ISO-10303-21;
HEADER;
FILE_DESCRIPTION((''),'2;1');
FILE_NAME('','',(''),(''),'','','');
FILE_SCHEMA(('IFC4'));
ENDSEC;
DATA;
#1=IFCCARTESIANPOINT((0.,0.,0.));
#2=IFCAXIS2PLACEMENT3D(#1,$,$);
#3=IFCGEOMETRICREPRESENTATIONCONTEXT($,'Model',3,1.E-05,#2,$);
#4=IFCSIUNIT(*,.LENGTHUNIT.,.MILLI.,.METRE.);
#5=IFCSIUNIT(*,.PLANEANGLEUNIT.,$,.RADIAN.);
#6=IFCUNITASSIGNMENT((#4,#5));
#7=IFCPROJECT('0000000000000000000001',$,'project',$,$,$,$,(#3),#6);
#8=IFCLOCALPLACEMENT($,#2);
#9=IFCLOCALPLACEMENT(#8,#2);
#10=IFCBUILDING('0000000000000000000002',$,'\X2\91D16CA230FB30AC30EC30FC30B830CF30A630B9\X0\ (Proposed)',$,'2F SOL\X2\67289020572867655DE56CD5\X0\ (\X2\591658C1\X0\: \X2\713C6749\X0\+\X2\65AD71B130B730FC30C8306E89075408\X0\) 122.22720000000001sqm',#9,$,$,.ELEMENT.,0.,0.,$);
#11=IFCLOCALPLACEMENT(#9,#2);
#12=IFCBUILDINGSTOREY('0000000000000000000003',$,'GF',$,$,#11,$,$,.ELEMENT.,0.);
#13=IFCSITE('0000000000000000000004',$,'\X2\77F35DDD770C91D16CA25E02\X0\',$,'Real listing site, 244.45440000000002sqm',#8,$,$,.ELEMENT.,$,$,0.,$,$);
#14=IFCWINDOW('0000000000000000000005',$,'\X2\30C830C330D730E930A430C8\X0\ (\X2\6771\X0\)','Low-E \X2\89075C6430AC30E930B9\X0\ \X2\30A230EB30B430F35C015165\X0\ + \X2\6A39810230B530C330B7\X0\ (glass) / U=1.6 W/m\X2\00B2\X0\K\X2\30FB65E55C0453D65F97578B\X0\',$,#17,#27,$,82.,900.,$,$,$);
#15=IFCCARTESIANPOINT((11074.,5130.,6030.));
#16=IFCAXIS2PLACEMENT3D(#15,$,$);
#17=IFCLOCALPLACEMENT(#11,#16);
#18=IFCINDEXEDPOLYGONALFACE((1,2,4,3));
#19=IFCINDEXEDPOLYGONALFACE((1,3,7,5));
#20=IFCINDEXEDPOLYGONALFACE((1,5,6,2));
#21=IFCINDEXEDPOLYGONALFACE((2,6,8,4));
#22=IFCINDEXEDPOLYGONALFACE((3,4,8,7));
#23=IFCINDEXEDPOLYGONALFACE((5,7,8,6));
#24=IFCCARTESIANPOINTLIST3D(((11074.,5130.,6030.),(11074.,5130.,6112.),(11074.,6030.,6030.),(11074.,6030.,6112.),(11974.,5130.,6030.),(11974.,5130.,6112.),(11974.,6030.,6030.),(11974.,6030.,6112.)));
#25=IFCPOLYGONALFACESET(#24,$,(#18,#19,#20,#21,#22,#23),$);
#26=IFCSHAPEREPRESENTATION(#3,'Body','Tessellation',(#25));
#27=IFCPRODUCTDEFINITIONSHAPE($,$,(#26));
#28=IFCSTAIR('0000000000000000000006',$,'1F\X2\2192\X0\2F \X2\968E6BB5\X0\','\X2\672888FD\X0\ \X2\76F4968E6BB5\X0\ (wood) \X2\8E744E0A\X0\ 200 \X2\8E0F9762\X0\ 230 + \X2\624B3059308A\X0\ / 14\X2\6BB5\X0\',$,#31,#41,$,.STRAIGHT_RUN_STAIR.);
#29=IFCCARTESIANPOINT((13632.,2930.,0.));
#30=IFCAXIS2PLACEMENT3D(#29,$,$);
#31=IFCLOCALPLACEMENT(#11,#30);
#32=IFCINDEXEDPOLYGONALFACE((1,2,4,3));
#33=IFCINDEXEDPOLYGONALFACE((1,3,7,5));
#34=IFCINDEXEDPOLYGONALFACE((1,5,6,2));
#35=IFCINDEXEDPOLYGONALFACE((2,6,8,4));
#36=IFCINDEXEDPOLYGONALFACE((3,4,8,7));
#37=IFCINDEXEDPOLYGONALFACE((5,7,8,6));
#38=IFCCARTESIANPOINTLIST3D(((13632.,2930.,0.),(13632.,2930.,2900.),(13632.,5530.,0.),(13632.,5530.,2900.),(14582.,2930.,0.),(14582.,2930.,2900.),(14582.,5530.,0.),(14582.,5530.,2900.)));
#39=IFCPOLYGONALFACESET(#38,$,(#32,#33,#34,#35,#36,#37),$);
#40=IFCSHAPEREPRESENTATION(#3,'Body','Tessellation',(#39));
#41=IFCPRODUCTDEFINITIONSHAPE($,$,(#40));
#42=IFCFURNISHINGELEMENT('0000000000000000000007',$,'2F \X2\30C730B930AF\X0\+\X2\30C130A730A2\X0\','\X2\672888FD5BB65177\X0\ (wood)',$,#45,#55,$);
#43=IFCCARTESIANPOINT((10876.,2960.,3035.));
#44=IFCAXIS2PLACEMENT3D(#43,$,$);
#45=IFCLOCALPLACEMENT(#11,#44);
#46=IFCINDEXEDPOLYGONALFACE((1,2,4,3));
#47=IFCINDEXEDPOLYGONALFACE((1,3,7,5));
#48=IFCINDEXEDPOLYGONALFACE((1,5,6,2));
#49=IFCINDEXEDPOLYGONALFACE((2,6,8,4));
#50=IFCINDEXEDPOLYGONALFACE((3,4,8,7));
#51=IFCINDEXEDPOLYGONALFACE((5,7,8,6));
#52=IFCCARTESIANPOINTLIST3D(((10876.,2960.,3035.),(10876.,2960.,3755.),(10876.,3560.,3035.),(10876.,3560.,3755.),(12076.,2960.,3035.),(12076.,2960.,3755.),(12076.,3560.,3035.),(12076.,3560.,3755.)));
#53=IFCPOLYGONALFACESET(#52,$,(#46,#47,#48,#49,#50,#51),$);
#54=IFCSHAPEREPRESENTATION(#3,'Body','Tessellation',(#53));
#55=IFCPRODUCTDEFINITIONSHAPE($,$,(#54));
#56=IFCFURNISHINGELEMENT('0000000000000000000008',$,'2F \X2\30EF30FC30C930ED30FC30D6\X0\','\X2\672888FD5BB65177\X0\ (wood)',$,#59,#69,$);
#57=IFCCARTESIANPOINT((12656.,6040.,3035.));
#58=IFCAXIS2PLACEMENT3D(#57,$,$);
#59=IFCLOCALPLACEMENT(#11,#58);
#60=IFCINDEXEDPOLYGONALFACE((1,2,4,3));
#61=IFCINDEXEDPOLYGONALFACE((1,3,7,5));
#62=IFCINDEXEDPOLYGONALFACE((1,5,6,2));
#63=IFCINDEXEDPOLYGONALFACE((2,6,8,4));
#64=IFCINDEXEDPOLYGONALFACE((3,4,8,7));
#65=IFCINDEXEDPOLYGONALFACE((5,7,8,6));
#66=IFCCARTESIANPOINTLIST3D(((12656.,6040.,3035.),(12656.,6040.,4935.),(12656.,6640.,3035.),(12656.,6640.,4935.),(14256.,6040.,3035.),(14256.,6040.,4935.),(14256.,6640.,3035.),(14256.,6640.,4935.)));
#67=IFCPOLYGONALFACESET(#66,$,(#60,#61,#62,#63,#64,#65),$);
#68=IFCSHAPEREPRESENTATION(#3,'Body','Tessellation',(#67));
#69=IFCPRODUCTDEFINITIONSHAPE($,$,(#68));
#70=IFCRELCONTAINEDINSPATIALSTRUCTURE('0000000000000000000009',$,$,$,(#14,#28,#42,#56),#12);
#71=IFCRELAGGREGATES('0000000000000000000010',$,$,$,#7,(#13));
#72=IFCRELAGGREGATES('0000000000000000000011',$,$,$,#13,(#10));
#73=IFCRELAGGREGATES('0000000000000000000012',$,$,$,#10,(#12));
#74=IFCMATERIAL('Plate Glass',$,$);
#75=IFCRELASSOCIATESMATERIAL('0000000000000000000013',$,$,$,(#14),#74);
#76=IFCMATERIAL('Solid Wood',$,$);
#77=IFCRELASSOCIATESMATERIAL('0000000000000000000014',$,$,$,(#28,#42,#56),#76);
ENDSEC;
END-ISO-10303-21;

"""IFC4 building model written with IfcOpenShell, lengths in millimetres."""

from ifc_helpers import new_model, si_unit, frame, frame_2d, origin, place, context, project, spatial, rectangle, extrude, material, element, save


model = new_model("IFC4")

# Units and contexts
model_context = context("Model", 3, precision=1e-05, world=origin())
ifc_project = project(units=[si_unit("LENGTHUNIT", "METRE", prefix="MILLI"), si_unit("PLANEANGLEUNIT", "RADIAN")], contexts=[model_context])

# Site, building, storey
site_placement = place(None, origin())
site = spatial("IfcSite", under=ifc_project, at=site_placement, Name="石川県金沢市", ObjectType="Real listing site, 244.45440000000002sqm", CompositionType="ELEMENT", RefElevation=0.0)
building_placement = place(site_placement, origin())
building = spatial("IfcBuilding", under=site, at=building_placement, Name="金沢・ガレージハウス (Proposed)", ObjectType="2F SOL木造在来工法 (外壁: 焼杉+断熱シートの複合) 122.22720000000001sqm", CompositionType="ELEMENT", ElevationOfRefHeight=0.0, ElevationOfTerrain=0.0)
storey_placement = place(building_placement, origin())
storey = spatial("IfcBuildingStorey", under=building, at=storey_placement, Name="GF", CompositionType="ELEMENT", Elevation=0.0)

# Shared definitions
ifc_material_1 = material(Name="Solid Wood")

# Shared definitions
ifc_material_2 = material(Name="Plate Glass")

# Window
window_1_placement = place(storey_placement, frame((11074.0, 5130.0, 6030.0)))
element("IfcWindow", 1, at=window_1_placement, inside=storey, material=ifc_material_2, Name="トップライト (東)", Description="Low-E 複層ガラス アルゴン封入 + 樹脂サッシ (glass) / U=1.6 W/m²K・日射取得型", OverallHeight=82.0, OverallWidth=900.0, context=model_context, shape_type="SweptSolid", body=[
    extrude(rectangle(XDim=900.0, YDim=900.0, at=frame_2d((450.0, 450.0))), frame((11074.0, 5130.0, 6030.0)), (0.0, 0.0, 1.0), 82.0),
])

# Stair
stair_placement = place(storey_placement, frame((13632.0, 2930.0, 0.0)))
element("IfcStair", 2, at=stair_placement, inside=storey, material=ifc_material_1, Name="1F→2F 階段", Description="木製 直階段 (wood) 蹴上 200 踏面 230 + 手すり / 14段", PredefinedType="STRAIGHT_RUN_STAIR", context=model_context, shape_type="SweptSolid", body=[
    extrude(rectangle(XDim=950.0, YDim=2600.0, at=frame_2d((475.0, 1300.0))), frame((13632.0, 2930.0, 0.0)), (0.0, 0.0, 1.0), 2900.0),
])

# Furnishing elements
furnishing_1_placement = place(storey_placement, frame((10876.0, 2960.0, 3035.0)))
element("IfcFurnishingElement", 3, at=furnishing_1_placement, inside=storey, material=ifc_material_1, Name="2F デスク+チェア", Description="木製家具 (wood)", context=model_context, shape_type="SweptSolid", body=[
    extrude(rectangle(XDim=1200.0, YDim=600.0, at=frame_2d((600.0, 300.0))), frame((10876.0, 2960.0, 3035.0)), (0.0, 0.0, 1.0), 720.0),
])
furnishing_2_placement = place(storey_placement, frame((12656.0, 6040.0, 3035.0)))
element("IfcFurnishingElement", 4, at=furnishing_2_placement, inside=storey, material=ifc_material_1, Name="2F ワードローブ", Description="木製家具 (wood)", context=model_context, shape_type="SweptSolid", body=[
    extrude(rectangle(XDim=1600.0, YDim=600.0, at=frame_2d((800.0, 300.0))), frame((12656.0, 6040.0, 3035.0)), (0.0, 0.0, 1.0), 1900.0),
])

save(model, "model.ifc")
